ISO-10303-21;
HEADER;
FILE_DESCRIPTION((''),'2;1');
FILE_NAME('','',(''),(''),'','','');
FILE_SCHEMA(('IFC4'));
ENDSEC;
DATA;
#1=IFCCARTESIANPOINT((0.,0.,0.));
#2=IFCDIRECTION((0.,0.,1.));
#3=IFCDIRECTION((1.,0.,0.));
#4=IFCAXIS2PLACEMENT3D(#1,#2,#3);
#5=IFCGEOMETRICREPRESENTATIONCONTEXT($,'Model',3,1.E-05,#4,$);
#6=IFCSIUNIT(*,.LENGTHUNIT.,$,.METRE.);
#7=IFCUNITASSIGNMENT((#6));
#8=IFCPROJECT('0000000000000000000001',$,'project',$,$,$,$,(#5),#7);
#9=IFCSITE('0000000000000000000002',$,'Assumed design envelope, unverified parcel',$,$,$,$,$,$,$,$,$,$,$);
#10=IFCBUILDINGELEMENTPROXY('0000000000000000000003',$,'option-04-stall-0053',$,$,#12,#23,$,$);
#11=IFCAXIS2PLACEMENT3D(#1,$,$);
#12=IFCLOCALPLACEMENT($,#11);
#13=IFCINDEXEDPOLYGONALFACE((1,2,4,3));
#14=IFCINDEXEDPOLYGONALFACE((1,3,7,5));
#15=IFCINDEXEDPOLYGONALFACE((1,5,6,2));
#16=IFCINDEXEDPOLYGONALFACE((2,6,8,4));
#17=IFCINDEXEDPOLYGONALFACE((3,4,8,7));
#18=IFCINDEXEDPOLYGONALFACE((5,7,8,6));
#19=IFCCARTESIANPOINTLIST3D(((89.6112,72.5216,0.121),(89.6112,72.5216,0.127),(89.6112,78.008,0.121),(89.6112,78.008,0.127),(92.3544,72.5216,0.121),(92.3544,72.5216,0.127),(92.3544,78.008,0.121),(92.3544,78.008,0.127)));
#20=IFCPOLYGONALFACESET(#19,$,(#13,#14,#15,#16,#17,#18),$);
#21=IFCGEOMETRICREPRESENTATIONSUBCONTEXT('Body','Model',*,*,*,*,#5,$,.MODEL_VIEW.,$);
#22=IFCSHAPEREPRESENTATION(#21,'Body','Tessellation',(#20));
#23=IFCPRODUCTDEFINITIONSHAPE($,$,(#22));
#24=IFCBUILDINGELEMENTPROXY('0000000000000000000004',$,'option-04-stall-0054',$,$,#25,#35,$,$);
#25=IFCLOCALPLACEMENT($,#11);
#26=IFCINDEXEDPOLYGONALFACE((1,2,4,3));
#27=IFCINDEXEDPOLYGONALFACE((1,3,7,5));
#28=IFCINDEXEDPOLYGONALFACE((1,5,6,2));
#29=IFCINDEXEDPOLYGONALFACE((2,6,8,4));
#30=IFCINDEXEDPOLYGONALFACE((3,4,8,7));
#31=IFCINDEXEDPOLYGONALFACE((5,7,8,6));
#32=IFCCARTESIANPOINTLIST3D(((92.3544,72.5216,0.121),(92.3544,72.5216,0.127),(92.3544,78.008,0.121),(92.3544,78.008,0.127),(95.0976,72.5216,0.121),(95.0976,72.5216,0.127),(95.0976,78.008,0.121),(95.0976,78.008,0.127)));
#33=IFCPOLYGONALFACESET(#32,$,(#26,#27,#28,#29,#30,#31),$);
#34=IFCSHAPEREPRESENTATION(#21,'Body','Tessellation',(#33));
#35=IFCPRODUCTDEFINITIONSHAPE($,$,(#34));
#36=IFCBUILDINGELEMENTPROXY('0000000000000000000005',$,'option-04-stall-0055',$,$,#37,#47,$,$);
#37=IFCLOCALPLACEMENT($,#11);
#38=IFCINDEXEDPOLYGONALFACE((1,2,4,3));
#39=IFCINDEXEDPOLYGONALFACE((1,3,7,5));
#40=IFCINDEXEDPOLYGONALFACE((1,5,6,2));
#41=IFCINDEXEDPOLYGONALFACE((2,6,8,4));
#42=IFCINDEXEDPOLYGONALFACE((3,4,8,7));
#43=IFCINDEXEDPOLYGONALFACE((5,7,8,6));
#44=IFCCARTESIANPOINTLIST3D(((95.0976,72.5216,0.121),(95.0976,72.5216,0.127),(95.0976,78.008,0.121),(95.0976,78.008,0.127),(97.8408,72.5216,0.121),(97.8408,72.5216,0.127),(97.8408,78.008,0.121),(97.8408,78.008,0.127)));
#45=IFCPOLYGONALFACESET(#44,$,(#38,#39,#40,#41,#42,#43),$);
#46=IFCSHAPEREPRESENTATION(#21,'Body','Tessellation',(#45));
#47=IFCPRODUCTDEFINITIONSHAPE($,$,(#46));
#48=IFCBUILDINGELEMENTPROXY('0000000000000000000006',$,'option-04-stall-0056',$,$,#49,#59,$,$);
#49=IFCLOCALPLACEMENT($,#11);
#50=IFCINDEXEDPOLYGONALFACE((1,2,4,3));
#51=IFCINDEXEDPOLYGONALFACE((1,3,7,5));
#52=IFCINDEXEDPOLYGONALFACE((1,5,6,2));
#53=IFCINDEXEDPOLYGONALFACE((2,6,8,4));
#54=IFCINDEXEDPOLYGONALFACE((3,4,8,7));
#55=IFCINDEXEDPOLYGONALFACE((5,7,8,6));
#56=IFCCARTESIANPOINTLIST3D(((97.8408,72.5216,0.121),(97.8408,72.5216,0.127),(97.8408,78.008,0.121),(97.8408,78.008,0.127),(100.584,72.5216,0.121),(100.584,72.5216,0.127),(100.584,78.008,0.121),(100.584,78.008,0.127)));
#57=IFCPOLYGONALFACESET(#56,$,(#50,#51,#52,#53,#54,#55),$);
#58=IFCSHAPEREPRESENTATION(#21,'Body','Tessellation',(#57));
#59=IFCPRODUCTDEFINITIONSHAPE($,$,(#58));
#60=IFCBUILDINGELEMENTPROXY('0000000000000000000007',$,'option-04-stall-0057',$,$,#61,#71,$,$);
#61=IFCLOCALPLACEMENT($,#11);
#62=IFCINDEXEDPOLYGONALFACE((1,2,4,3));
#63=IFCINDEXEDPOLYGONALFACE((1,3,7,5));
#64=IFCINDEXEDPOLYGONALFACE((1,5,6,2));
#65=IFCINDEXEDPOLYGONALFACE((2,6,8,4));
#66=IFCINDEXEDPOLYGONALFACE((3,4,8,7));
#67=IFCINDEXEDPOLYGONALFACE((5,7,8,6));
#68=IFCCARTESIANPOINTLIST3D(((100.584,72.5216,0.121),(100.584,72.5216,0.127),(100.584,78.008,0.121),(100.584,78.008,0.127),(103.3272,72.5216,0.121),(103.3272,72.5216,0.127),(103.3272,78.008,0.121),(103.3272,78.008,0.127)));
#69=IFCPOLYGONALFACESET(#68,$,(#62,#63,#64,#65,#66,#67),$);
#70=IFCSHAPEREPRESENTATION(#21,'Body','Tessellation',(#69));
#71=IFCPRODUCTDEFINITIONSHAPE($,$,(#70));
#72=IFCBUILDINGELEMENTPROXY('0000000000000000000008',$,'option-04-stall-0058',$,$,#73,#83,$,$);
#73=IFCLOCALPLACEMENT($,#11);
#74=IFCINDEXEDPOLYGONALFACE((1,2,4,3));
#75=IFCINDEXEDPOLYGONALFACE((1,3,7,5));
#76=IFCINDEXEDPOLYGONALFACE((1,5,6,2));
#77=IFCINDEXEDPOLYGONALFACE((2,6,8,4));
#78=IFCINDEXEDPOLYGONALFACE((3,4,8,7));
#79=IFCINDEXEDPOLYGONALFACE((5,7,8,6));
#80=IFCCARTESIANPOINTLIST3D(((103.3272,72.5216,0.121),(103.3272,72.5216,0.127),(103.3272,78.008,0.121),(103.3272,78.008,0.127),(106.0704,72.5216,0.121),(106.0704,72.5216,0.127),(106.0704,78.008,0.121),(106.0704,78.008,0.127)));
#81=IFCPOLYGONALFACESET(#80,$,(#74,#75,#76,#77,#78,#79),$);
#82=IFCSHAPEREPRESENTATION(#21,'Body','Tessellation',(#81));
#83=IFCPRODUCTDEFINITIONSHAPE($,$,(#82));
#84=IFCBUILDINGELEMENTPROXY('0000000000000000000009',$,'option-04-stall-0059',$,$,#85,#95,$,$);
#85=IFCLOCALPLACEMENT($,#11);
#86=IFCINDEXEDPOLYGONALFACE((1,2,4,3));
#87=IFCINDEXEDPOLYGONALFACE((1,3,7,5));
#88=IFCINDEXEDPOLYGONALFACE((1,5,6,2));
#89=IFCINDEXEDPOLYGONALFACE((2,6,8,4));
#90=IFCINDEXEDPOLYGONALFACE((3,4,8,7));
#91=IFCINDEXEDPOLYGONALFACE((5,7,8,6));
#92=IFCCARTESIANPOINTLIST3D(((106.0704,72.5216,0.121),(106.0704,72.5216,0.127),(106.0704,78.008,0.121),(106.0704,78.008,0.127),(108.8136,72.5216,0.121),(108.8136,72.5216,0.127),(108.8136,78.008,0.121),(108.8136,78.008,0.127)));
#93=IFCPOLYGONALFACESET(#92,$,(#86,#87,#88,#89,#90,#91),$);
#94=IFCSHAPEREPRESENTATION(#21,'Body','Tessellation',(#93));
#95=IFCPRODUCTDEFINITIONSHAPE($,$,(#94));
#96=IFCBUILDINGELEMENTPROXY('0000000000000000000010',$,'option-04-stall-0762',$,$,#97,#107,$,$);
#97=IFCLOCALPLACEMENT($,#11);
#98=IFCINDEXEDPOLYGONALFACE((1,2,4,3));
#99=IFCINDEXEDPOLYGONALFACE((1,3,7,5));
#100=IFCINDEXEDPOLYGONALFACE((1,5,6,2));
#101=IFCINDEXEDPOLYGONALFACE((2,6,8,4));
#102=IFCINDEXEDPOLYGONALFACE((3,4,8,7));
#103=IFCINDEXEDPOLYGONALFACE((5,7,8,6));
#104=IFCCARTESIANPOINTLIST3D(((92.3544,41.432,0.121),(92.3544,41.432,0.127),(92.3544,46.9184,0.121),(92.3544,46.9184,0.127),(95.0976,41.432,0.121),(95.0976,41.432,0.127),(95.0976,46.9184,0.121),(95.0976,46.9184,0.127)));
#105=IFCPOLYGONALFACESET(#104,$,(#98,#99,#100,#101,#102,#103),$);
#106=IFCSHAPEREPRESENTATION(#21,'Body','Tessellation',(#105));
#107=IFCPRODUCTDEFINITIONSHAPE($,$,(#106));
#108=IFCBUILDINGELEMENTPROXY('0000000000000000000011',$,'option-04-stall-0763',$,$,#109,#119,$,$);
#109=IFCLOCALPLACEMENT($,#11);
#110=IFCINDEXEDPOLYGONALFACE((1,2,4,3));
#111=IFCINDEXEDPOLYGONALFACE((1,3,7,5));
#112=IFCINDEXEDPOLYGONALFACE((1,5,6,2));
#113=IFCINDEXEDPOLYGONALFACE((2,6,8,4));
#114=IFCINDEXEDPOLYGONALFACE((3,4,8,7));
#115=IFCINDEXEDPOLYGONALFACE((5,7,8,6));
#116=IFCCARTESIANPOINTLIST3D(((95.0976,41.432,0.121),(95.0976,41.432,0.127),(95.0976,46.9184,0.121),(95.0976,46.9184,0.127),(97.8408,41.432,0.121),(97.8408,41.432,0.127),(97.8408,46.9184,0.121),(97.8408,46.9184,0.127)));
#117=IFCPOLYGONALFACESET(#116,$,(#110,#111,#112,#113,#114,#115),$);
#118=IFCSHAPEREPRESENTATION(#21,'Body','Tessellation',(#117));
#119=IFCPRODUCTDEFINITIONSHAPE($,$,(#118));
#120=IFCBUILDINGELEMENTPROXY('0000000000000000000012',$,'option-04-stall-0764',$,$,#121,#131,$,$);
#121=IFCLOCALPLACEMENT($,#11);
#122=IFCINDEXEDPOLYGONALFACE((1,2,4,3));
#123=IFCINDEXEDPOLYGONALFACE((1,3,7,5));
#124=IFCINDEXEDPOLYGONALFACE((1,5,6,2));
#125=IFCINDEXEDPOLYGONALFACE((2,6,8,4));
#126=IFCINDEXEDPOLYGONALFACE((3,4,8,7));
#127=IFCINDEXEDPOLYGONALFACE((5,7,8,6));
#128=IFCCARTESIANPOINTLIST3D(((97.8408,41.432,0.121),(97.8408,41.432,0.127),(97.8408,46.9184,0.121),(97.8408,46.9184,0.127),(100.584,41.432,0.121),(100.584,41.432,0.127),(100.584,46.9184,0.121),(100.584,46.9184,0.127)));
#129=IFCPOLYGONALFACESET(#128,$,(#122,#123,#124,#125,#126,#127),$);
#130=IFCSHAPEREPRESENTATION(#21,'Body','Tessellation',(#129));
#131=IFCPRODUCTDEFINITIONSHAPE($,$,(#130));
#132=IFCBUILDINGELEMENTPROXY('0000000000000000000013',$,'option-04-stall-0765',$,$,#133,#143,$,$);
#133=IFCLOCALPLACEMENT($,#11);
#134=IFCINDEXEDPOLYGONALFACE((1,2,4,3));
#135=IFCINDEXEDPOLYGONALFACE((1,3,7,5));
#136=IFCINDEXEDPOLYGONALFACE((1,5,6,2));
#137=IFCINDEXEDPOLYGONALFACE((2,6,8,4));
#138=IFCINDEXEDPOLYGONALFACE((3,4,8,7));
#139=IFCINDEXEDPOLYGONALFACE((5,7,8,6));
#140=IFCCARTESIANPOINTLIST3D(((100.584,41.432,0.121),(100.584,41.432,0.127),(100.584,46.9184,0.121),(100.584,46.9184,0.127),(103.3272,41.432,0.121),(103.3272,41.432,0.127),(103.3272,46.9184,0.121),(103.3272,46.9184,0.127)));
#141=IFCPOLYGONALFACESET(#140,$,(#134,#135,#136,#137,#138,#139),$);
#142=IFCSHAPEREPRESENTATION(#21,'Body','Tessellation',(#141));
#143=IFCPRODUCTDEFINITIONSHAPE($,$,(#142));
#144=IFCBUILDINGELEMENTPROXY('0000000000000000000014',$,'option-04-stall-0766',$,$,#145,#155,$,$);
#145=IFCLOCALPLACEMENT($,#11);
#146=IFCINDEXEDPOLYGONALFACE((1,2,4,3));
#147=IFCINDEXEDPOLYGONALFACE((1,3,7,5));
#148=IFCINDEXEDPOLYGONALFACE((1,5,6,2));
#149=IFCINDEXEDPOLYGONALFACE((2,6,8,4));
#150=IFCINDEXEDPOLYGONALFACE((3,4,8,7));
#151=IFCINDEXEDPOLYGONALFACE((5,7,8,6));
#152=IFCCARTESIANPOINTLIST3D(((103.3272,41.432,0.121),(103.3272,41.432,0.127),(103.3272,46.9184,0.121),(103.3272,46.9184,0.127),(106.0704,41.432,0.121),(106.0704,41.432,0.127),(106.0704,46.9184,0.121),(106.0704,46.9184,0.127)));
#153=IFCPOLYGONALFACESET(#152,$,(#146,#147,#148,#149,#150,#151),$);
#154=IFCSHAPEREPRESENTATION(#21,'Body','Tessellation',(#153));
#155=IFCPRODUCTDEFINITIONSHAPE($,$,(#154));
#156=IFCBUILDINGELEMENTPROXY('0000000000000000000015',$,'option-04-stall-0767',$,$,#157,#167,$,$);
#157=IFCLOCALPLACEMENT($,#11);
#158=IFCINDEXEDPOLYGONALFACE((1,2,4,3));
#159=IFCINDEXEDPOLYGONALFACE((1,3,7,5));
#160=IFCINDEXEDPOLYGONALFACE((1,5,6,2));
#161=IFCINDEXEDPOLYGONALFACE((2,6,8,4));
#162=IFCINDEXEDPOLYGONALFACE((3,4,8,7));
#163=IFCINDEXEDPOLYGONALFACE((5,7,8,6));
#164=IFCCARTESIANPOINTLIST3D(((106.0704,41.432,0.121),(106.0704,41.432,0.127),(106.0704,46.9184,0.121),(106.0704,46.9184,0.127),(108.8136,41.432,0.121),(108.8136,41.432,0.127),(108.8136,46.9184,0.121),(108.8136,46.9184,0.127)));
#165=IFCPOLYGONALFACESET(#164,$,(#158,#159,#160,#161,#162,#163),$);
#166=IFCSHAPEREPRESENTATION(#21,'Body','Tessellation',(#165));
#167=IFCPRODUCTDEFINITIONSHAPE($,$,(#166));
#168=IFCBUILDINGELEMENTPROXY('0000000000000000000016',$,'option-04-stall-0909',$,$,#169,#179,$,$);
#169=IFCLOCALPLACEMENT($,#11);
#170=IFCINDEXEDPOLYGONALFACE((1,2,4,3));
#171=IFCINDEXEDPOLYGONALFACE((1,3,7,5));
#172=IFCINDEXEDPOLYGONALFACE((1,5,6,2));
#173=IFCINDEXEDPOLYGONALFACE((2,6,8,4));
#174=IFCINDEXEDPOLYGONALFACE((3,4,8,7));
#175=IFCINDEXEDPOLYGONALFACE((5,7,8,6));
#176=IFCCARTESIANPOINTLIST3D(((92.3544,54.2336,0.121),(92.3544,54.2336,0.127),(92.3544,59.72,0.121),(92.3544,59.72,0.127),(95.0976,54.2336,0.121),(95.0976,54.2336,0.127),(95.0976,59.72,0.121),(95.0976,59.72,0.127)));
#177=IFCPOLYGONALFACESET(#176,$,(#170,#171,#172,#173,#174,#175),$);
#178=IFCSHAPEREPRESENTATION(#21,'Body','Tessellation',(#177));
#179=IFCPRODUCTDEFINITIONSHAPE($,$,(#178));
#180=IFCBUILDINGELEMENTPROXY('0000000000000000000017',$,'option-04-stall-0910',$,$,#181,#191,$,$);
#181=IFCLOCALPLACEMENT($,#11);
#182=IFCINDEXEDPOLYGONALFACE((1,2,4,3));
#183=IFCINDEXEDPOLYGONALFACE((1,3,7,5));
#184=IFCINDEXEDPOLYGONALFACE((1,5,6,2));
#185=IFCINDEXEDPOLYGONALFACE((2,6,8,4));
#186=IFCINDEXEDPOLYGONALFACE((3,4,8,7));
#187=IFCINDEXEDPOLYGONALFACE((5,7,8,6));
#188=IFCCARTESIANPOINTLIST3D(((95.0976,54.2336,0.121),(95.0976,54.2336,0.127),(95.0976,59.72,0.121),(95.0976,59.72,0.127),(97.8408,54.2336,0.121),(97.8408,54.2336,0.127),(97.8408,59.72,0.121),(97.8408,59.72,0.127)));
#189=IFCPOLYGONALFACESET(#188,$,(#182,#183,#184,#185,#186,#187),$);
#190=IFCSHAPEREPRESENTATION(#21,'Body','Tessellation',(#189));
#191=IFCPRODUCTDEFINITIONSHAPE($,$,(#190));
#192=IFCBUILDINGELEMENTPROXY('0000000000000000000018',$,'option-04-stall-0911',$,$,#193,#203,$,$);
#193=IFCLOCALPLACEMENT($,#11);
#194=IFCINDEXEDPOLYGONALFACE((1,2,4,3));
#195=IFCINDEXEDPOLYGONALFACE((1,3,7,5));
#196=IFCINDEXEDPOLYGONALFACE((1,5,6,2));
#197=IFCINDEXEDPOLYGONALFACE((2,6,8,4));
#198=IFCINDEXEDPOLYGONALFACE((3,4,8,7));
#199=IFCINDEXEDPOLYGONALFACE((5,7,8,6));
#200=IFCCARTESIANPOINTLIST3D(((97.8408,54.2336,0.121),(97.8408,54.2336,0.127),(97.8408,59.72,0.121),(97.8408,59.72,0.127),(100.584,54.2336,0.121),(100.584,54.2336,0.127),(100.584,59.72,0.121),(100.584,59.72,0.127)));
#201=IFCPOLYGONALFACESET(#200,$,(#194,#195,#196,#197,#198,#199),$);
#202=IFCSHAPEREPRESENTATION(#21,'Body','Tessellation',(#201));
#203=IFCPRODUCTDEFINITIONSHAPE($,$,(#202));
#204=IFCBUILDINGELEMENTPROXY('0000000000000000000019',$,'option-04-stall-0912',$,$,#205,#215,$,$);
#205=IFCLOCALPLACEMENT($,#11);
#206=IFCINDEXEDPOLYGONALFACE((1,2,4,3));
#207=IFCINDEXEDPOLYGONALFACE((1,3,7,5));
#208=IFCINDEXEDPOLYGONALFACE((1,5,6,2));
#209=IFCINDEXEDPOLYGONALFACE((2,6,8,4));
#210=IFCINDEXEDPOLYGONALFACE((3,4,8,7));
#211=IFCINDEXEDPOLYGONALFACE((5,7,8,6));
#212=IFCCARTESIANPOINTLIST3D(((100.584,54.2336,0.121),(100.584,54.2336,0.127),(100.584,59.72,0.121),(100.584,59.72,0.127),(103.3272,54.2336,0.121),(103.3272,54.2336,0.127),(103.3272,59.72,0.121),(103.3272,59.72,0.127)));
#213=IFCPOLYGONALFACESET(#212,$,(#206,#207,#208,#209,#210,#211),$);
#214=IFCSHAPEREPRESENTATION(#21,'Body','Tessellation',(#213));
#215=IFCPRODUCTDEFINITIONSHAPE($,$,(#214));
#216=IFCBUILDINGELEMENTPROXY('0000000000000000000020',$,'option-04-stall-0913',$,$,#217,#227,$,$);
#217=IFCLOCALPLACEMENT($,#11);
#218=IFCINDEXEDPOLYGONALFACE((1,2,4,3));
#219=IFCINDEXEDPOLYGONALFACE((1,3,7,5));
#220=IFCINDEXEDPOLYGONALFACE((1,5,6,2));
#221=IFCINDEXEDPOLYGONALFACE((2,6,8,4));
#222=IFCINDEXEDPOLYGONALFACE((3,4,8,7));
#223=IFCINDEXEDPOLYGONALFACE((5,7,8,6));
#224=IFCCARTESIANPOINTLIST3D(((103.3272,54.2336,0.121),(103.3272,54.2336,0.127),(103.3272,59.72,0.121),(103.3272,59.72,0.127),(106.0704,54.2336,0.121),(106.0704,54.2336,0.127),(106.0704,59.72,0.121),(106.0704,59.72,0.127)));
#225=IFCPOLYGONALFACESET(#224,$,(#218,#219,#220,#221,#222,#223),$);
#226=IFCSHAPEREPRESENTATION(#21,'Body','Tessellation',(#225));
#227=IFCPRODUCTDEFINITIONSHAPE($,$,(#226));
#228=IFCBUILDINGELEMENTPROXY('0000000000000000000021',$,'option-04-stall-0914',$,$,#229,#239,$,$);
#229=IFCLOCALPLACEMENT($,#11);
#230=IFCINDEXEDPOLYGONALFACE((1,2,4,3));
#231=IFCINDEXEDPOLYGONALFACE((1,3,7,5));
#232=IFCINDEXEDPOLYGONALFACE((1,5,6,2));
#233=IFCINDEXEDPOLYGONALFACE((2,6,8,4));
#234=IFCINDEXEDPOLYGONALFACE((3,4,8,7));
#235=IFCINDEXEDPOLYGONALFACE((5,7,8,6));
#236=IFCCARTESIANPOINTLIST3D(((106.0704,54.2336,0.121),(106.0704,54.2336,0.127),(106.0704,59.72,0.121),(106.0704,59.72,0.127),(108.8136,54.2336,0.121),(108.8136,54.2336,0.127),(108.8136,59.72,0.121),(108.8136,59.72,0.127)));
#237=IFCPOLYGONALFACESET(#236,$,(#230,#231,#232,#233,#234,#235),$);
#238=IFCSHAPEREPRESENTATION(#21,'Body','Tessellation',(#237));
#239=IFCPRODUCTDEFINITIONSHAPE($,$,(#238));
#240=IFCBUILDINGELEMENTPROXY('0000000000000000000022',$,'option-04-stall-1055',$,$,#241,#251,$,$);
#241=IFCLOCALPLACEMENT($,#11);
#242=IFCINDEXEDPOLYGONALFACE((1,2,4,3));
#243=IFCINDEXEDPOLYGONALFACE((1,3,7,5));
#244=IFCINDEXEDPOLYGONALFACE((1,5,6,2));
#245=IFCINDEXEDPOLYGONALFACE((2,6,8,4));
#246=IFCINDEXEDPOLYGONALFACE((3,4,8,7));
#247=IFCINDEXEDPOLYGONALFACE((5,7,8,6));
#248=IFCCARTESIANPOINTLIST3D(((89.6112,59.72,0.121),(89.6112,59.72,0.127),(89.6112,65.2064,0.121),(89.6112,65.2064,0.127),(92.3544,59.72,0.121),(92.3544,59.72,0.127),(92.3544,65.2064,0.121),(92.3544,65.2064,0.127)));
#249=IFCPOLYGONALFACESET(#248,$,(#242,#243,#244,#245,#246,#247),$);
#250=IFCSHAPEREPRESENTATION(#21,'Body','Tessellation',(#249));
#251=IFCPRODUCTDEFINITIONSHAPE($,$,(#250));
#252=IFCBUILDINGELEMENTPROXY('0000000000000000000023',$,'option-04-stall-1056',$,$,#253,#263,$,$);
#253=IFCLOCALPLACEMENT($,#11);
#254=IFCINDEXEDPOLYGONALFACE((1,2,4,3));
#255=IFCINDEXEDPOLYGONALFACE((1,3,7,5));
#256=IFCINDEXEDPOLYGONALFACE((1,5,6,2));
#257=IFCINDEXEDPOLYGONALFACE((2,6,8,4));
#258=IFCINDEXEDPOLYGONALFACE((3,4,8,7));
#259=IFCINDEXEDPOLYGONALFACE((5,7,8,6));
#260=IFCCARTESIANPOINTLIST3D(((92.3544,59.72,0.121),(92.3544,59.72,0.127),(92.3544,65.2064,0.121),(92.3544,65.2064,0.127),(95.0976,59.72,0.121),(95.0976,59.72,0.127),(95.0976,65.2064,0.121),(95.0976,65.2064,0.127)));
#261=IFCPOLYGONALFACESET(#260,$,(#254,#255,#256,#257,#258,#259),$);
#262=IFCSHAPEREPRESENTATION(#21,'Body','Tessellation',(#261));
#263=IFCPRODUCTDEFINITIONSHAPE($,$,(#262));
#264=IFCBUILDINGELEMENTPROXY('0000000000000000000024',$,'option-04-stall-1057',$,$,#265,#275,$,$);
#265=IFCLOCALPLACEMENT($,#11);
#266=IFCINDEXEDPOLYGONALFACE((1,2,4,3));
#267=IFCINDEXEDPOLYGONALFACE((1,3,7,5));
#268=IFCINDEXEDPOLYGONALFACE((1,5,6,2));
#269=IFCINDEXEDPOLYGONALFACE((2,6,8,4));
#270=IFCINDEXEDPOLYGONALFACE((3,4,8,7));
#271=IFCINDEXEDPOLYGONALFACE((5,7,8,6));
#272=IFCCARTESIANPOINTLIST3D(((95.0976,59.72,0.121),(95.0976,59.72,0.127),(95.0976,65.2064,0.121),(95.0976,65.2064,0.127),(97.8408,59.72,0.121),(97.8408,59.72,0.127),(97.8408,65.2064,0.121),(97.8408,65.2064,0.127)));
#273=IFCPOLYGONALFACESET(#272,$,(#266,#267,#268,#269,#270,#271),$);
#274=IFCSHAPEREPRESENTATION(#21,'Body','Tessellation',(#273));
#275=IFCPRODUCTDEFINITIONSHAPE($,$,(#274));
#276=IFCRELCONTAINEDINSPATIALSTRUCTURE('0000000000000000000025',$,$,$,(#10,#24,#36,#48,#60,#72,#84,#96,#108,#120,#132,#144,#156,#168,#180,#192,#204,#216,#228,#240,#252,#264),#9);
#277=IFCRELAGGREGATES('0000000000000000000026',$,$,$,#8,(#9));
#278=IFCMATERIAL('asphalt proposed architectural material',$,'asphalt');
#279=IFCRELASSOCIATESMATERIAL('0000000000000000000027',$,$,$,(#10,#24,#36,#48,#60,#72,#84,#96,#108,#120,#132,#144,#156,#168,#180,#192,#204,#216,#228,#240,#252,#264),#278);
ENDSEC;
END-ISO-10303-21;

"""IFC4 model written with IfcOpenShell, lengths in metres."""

from ifc_helpers import new_model, si_unit, frame, origin_with_axes, place, context, subcontext, project, spatial, rectangle, extrude, material, element, save


model = new_model("IFC4")

# Units and contexts
model_context = context("Model", 3, precision=1e-05, world=origin_with_axes())
body_context = subcontext(model_context, "Body", "Model", "MODEL_VIEW")
ifc_project = project(units=[si_unit("LENGTHUNIT", "METRE")], contexts=[model_context])

# Site
site = spatial("IfcSite", under=ifc_project, Name="Assumed design envelope, unverified parcel")

# Building element proxies
ifc_material = material(Name="asphalt proposed architectural material", Category="asphalt")
for number, where, z_axis, x_axis, name in (
    (1, (90.9828, 75.2648, 0.121), (0.0, 0.0, 1.0), (1.0, 0.0, 0.0), "option-04-stall-0053"),
    (2, (93.726, 75.2648, 0.121), (0.0, 0.0, 1.0), (1.0, 0.0, 0.0), "option-04-stall-0054"),
    (3, (96.4692, 75.2648, 0.121), (0.0, 0.0, 1.0), (1.0, 0.0, 0.0), "option-04-stall-0055"),
    (4, (99.2124, 75.2648, 0.121), (0.0, 0.0, 1.0), (1.0, 0.0, 0.0), "option-04-stall-0056"),
    (5, (101.9556, 75.2648, 0.121), (0.0, 0.0, 1.0), (1.0, 0.0, 0.0), "option-04-stall-0057"),
    (6, (104.6988, 75.2648, 0.121), (0.0, 0.0, 1.0), (1.0, 0.0, 0.0), "option-04-stall-0058"),
    (7, (107.442, 75.2648, 0.121), (0.0, 0.0, 1.0), (1.0, 0.0, 0.0), "option-04-stall-0059"),
    (8, (93.726, 44.1752, 0.121), (0.0, 0.0, 1.0), (1.0, 0.0, 0.0), "option-04-stall-0762"),
    (9, (96.4692, 44.1752, 0.121), (0.0, 0.0, 1.0), (1.0, 0.0, 0.0), "option-04-stall-0763"),
    (10, (99.2124, 44.1752, 0.121), (0.0, 0.0, 1.0), (1.0, 0.0, 0.0), "option-04-stall-0764"),
    (11, (101.9556, 44.1752, 0.121), (0.0, 0.0, 1.0), (1.0, 0.0, 0.0), "option-04-stall-0765"),
    (12, (104.6988, 44.1752, 0.121), (0.0, 0.0, 1.0), (1.0, 0.0, 0.0), "option-04-stall-0766"),
    (13, (107.442, 44.1752, 0.121), (0.0, 0.0, 1.0), (1.0, 0.0, 0.0), "option-04-stall-0767"),
    (14, (93.726, 56.9768, 0.121), (0.0, 0.0, 1.0), (1.0, 0.0, 0.0), "option-04-stall-0909"),
    (15, (96.4692, 56.9768, 0.121), (0.0, 0.0, 1.0), (1.0, 0.0, 0.0), "option-04-stall-0910"),
    (16, (99.2124, 56.9768, 0.121), (0.0, 0.0, 1.0), (1.0, 0.0, 0.0), "option-04-stall-0911"),
    (17, (101.9556, 56.9768, 0.121), (0.0, 0.0, 1.0), (1.0, 0.0, 0.0), "option-04-stall-0912"),
    (18, (104.6988, 56.9768, 0.121), (0.0, 0.0, 1.0), (1.0, 0.0, 0.0), "option-04-stall-0913"),
    (19, (107.442, 56.9768, 0.121), (0.0, 0.0, 1.0), (1.0, 0.0, 0.0), "option-04-stall-0914"),
    (20, (90.9828, 62.4632, 0.121), (0.0, 0.0, 1.0), (1.0, 0.0, 0.0), "option-04-stall-1055"),
    (21, (93.726, 62.4632, 0.121), (0.0, 0.0, 1.0), (1.0, 0.0, 0.0), "option-04-stall-1056"),
    (22, (96.4692, 62.4632, 0.121), (0.0, 0.0, 1.0), (1.0, 0.0, 0.0), "option-04-stall-1057"),
):
    element("IfcBuildingElementProxy", number, at=place(None, frame(where, z_axis=z_axis, x_axis=x_axis)), inside=site, material=ifc_material, Name=name, context=body_context, shape_type="SweptSolid", body=[
        extrude(rectangle(XDim=2.7432, YDim=5.4864), origin_with_axes(), (0.0, 0.0, 1.0), 0.006),
    ])

save(model, "model.ifc")
